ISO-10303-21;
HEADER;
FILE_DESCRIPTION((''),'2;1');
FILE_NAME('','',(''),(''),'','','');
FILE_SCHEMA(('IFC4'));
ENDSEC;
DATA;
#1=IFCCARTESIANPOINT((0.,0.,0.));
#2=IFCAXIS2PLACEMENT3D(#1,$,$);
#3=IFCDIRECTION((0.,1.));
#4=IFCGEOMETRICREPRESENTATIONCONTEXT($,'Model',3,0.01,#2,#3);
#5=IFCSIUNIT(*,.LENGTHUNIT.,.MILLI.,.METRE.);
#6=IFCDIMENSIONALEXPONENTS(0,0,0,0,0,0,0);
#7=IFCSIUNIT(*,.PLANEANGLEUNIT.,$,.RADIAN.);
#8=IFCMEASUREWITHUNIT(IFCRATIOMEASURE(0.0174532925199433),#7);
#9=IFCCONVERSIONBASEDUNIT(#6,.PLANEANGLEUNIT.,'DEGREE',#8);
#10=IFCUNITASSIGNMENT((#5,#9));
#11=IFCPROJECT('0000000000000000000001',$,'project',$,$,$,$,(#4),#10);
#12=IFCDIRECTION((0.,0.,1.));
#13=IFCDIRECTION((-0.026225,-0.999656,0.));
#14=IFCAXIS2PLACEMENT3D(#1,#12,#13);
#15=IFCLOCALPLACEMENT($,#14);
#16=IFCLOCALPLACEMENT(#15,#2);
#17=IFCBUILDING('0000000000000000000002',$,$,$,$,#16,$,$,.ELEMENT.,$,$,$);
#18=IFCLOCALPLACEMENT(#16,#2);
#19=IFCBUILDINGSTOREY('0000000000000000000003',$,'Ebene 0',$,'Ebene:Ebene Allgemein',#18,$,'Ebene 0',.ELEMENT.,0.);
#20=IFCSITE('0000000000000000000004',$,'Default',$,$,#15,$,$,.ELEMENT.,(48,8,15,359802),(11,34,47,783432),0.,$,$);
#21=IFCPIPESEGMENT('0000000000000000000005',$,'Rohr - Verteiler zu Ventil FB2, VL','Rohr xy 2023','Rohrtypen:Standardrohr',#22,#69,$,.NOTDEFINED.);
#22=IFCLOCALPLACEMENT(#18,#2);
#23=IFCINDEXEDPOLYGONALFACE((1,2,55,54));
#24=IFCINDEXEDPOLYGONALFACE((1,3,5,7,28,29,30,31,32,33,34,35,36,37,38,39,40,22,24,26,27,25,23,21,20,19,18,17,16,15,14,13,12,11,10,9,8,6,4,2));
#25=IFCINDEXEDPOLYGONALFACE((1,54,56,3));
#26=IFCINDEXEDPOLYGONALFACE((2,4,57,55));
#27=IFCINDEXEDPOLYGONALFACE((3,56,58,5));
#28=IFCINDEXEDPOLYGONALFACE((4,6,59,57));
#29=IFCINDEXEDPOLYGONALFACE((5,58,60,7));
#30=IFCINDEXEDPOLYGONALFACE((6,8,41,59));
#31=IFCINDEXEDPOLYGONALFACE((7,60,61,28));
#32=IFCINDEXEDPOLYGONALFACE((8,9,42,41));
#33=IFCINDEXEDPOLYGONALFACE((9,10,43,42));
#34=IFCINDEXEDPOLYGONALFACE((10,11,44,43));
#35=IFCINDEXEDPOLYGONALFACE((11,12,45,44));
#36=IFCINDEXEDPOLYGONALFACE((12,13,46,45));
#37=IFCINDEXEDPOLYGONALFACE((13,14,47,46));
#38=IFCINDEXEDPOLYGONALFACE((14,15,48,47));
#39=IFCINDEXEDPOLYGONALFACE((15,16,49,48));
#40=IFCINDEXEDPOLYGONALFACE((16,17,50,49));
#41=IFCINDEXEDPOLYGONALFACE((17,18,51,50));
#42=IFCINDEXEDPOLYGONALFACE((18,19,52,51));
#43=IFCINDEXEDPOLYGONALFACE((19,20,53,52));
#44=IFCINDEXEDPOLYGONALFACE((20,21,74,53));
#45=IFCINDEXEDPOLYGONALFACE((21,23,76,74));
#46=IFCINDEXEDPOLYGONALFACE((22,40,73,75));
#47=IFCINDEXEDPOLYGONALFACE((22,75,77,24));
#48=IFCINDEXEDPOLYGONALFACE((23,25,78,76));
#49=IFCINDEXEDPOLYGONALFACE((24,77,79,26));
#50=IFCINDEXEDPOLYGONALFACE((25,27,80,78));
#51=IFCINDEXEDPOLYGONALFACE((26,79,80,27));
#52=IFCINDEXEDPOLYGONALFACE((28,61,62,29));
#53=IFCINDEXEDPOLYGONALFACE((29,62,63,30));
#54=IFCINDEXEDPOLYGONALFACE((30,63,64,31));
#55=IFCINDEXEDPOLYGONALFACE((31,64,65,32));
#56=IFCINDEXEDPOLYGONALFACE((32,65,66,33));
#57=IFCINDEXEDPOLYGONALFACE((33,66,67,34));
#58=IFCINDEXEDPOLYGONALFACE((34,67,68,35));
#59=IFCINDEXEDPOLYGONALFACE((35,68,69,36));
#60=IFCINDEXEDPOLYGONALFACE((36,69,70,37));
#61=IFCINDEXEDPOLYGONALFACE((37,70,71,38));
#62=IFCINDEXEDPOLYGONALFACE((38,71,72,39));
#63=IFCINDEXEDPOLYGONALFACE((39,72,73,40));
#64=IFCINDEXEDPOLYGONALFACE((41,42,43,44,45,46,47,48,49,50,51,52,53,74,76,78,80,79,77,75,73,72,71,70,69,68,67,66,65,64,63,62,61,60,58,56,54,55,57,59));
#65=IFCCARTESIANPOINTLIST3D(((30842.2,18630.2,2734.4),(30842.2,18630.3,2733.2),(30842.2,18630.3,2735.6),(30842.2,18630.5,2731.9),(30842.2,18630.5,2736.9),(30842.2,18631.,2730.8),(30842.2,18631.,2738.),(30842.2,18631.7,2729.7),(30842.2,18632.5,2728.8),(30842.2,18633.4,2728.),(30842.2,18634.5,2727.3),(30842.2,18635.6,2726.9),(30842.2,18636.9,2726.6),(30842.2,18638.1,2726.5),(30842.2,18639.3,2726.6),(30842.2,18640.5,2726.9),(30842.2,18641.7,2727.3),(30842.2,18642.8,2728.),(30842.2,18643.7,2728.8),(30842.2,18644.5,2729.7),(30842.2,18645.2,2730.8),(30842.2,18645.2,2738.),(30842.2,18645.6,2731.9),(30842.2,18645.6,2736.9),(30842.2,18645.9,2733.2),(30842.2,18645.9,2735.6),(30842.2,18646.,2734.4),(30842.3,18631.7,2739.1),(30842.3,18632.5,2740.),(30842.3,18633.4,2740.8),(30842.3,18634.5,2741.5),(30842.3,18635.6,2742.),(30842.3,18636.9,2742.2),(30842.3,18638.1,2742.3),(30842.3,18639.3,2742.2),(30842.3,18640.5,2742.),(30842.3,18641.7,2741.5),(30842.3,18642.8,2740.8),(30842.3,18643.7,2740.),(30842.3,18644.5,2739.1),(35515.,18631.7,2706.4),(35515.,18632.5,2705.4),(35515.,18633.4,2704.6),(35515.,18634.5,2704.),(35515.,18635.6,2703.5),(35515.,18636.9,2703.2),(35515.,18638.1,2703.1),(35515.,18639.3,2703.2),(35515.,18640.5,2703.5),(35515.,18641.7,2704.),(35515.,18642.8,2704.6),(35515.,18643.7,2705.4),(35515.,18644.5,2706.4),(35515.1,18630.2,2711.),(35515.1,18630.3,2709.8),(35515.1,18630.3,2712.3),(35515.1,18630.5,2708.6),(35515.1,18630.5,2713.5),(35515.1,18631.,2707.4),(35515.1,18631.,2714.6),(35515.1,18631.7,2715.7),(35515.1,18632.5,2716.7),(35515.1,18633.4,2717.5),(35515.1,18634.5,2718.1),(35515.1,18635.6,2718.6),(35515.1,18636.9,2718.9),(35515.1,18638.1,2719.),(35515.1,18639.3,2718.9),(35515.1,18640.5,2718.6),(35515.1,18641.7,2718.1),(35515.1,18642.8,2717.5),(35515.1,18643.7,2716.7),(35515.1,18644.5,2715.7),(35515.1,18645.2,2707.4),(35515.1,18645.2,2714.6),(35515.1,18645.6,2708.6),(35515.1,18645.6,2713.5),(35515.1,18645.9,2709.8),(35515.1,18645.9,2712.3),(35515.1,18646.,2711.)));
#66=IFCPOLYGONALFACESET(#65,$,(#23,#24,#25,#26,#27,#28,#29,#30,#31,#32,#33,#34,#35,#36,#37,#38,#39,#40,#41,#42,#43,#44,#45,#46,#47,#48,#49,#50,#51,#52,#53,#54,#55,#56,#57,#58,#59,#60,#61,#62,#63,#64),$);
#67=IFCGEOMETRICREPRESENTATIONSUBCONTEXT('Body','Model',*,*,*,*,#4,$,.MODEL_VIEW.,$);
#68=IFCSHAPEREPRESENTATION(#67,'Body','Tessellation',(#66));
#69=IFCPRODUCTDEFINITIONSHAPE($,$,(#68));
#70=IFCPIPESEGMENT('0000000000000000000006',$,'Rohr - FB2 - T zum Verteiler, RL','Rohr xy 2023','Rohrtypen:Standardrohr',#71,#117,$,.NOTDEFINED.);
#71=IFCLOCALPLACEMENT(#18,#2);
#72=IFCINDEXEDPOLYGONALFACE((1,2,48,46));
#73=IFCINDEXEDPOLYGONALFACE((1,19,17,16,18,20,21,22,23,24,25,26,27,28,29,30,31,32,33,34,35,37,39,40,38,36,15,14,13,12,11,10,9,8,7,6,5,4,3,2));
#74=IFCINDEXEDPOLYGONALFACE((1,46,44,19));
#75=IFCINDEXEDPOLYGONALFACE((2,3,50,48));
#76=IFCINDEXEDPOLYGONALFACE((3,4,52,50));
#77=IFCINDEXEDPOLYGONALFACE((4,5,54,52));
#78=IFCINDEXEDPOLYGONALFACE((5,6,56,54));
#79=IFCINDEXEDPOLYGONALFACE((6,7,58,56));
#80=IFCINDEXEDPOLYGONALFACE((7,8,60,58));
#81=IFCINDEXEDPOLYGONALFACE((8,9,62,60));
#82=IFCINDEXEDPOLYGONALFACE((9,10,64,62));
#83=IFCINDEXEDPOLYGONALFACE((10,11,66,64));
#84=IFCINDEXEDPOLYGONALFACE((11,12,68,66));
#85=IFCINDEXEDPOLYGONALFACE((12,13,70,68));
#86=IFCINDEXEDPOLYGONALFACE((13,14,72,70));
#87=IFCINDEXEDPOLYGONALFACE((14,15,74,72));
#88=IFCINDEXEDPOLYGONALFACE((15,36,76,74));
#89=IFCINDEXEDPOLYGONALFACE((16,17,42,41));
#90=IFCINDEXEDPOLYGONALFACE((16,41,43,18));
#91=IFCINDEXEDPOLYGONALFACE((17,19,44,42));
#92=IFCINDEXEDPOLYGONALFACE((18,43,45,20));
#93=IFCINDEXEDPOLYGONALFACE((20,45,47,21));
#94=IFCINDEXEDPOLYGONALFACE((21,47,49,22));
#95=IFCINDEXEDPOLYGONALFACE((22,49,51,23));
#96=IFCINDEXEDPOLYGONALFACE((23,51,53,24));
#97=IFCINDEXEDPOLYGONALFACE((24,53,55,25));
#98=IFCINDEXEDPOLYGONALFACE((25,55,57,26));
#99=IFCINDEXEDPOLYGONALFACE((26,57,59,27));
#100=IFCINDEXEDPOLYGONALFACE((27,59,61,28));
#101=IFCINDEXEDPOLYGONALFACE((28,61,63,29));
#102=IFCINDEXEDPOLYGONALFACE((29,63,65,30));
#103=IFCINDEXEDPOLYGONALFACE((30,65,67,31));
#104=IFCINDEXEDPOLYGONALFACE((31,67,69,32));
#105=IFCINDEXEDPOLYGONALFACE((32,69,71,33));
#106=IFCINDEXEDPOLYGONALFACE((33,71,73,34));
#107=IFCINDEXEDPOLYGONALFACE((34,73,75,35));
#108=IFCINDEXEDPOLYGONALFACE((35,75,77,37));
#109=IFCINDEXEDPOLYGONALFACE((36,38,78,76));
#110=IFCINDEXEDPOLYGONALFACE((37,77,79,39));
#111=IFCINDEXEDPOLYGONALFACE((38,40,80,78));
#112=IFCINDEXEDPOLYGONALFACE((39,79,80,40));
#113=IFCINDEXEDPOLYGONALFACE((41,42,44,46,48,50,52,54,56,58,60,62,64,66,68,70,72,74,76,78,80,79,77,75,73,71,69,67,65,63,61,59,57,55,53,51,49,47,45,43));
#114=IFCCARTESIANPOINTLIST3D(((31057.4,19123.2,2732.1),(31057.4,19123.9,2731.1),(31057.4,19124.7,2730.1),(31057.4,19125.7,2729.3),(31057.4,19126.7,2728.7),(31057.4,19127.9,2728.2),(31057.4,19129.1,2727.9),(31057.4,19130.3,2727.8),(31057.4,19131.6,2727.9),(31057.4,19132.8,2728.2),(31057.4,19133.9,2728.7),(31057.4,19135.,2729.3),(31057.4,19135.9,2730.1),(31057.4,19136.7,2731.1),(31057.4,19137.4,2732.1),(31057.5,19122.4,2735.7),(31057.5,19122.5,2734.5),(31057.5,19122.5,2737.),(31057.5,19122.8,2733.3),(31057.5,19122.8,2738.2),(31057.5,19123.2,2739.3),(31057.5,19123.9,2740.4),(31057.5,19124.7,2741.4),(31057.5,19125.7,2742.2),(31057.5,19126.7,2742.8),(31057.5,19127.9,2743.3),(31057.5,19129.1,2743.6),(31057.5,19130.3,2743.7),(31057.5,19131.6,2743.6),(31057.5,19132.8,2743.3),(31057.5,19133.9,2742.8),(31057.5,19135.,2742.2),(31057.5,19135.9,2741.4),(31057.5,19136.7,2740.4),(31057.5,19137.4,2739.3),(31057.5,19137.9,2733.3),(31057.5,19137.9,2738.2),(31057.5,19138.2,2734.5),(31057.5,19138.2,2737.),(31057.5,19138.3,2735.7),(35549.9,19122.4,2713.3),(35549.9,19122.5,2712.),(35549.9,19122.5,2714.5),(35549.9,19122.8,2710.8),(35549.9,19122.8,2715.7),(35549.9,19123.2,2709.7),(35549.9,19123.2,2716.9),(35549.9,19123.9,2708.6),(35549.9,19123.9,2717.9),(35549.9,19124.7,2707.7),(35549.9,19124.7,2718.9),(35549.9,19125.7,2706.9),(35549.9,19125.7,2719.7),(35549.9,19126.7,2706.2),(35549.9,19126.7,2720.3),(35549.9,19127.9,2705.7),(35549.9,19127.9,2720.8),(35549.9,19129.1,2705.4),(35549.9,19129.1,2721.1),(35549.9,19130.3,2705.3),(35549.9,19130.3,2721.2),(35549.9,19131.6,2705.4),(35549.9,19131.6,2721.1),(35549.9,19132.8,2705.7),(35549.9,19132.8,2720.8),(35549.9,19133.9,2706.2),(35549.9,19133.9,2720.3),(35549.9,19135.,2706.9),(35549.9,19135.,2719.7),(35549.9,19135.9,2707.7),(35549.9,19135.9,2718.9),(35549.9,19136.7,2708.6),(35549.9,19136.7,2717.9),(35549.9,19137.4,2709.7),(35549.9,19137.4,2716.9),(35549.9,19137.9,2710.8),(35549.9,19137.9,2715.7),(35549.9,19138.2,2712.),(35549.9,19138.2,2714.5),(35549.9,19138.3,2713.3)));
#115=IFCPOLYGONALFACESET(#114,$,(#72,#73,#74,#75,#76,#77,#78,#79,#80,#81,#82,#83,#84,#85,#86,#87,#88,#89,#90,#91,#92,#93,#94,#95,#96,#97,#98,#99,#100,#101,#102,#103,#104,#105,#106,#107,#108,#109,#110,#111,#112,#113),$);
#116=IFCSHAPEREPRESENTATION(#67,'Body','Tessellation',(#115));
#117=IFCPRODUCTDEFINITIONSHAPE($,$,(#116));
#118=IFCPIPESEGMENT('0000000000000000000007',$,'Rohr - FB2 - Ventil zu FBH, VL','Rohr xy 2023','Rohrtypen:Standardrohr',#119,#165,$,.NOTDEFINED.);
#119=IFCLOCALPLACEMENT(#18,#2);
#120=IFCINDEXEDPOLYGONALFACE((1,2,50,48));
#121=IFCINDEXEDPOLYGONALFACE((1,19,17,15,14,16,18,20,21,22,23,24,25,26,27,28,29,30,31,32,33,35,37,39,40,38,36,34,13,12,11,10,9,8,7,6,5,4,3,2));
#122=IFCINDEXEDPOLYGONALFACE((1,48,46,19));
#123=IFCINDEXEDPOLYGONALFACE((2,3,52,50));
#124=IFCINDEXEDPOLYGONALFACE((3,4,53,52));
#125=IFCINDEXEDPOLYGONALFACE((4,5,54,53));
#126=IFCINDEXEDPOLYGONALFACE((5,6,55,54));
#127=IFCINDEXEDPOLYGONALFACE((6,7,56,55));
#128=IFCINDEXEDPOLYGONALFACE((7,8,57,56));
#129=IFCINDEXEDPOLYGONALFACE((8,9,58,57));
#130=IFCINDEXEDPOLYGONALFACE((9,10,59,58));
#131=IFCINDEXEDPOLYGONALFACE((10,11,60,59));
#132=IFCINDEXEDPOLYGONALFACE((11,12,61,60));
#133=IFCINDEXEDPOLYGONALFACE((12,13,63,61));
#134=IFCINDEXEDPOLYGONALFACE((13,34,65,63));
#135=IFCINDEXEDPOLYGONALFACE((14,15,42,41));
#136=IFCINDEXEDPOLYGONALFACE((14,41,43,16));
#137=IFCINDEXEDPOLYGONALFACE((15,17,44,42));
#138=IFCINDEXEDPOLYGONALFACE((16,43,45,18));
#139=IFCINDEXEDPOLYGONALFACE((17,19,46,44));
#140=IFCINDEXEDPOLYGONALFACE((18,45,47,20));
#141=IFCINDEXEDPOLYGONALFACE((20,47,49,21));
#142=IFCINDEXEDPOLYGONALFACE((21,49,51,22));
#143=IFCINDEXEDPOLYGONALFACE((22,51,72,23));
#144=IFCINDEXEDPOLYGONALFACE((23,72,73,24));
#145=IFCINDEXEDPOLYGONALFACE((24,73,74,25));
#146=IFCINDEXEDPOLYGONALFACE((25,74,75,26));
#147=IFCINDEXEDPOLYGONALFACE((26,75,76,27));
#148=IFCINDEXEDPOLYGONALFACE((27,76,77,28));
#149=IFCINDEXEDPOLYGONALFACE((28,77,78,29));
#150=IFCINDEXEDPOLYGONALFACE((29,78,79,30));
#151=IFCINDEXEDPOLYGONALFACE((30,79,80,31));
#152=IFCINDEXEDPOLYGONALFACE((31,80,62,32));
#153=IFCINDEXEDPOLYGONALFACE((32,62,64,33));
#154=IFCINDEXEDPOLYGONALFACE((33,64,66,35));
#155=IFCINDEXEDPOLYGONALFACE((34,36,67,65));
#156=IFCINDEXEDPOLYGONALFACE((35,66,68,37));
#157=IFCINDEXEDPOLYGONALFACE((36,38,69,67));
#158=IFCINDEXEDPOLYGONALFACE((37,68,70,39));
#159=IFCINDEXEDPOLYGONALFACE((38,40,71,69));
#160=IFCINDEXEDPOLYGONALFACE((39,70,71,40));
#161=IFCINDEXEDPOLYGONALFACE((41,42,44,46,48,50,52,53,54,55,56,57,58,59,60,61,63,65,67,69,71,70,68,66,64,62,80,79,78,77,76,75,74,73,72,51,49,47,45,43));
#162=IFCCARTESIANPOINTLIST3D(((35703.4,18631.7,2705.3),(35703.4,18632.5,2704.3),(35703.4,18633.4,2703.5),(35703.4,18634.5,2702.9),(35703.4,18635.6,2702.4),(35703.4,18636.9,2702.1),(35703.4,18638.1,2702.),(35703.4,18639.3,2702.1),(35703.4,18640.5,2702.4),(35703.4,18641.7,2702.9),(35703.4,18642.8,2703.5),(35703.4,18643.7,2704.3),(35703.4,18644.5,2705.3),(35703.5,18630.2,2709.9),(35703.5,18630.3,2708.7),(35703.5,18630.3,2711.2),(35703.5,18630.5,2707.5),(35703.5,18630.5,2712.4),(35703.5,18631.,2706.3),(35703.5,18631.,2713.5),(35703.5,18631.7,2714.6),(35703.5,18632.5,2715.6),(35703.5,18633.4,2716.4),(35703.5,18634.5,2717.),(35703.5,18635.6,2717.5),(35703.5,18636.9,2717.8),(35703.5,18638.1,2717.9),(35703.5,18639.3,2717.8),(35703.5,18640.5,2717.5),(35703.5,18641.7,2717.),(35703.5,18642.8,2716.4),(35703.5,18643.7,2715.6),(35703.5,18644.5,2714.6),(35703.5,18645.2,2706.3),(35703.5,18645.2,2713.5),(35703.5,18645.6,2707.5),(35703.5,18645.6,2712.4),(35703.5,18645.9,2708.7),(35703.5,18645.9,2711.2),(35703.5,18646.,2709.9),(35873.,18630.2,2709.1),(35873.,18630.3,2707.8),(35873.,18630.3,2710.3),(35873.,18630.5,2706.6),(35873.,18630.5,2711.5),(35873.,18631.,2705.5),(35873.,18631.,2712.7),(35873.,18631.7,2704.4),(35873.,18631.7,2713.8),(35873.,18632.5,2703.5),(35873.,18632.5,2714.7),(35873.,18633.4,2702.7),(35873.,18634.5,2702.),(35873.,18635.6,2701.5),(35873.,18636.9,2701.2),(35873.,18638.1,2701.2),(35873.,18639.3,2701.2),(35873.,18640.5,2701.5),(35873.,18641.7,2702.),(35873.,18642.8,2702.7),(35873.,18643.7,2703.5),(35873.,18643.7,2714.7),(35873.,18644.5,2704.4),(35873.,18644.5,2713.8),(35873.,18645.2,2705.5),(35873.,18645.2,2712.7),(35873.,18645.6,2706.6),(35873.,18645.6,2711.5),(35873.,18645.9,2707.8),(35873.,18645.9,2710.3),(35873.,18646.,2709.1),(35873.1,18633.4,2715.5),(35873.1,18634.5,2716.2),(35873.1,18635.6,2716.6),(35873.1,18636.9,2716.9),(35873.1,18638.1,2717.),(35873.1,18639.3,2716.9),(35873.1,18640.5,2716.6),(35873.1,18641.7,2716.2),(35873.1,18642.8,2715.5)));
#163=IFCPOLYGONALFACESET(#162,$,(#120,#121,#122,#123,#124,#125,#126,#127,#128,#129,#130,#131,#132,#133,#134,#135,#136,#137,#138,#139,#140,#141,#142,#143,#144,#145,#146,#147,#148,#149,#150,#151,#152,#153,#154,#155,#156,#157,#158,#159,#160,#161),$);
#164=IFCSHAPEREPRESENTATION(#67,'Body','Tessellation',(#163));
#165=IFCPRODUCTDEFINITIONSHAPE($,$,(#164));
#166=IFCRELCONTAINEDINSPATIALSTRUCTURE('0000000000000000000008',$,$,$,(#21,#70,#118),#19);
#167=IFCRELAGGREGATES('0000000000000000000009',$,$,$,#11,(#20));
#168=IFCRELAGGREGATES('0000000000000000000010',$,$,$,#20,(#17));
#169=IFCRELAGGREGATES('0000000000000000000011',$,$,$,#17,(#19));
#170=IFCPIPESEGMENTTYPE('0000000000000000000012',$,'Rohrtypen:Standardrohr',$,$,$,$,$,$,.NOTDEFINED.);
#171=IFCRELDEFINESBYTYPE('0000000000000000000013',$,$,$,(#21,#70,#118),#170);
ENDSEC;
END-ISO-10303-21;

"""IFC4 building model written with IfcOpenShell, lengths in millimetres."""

from ifc_helpers import new_model, entity, si_unit, converted_unit, direction, frame, origin, place, context, subcontext, project, spatial, indexed_curve, outline, extrude, type_object, element, save


model = new_model("IFC4")

# Units and contexts
model_context = context("Model", 3, precision=0.01, world=origin(), true_north=direction((0.0, 1.0)))
body_context = subcontext(model_context, "Body", "Model", "MODEL_VIEW")
ifc_project = project(units=[si_unit("LENGTHUNIT", "METRE", prefix="MILLI"), converted_unit("PLANEANGLEUNIT", "DEGREE", entity("IfcRatioMeasure", 0.0174532925199433), si_unit("PLANEANGLEUNIT", "RADIAN"), dimensions=[0, 0, 0, 0, 0, 0, 0])], contexts=[model_context])

# Site, building, storey
site_placement = place(None, frame((0.0, 0.0, 0.0), z_axis=(0.0, 0.0, 1.0), x_axis=(-0.026225, -0.999656, 0.0)))
site = spatial("IfcSite", under=ifc_project, at=site_placement, Name="Default", CompositionType="ELEMENT", RefLatitude=(48, 8, 15, 359802), RefLongitude=(11, 34, 47, 783432), RefElevation=0.0)
building_placement = place(site_placement, origin())
building = spatial("IfcBuilding", under=site, at=building_placement, CompositionType="ELEMENT")
storey_placement = place(building_placement, origin())
storey = spatial("IfcBuildingStorey", under=building, at=storey_placement, Name="Ebene 0", ObjectType="Ebene:Ebene Allgemein", LongName="Ebene 0", CompositionType="ELEMENT", Elevation=0.0)

# Pipe segments
pipe_segment_type = type_object("IfcPipeSegmentType", Name="Rohrtypen:Standardrohr", PredefinedType="NOTDEFINED")
pipe_segment_1_placement = place(storey_placement, origin())
element("IfcPipeSegment", 1, at=pipe_segment_1_placement, inside=storey, type_object=pipe_segment_type, Name="Rohr - Verteiler zu Ventil FB2, VL", Description="Rohr xy 2023", ObjectType="Rohrtypen:Standardrohr", PredefinedType="NOTDEFINED", context=body_context, shape_type="SweptSolid", body=[
    extrude(outline(indexed_curve([(7.9, 0.0), (7.8, 1.2), (7.6, 2.5), (7.1, 3.6), (6.4, 4.7), (5.6, 5.6), (4.7, 6.4), (3.6, 7.1), (2.5, 7.6), (1.2, 7.8), (0.0, 7.9), (-1.2, 7.8), (-2.5, 7.6), (-3.6, 7.1), (-4.7, 6.4), (-5.6, 5.6), (-6.4, 4.7), (-7.1, 3.6), (-7.6, 2.5), (-7.8, 1.2), (-7.9, 0.0), (-7.8, -1.2), (-7.6, -2.5), (-7.1, -3.6), (-6.4, -4.7), (-5.6, -5.6), (-4.7, -6.4), (-3.6, -7.1), (-2.5, -7.6), (-1.2, -7.8), (0.0, -7.9), (1.2, -7.8), (2.5, -7.6), (3.6, -7.1), (4.7, -6.4), (5.6, -5.6), (6.4, -4.7), (7.1, -3.6), (7.6, -2.5), (7.8, -1.2), (7.9, 0.0)], self_intersect=False)), frame((35515.1, 18638.1, 2711.0), z_axis=(-0.999988, 0.0, 0.005), x_axis=(0.0, 1.0, 0.0)), (0.0, 0.0, 1.0), 4672.9),
])
pipe_segment_2_placement = place(storey_placement, origin())
element("IfcPipeSegment", 2, at=pipe_segment_2_placement, inside=storey, type_object=pipe_segment_type, Name="Rohr - FB2 - T zum Verteiler, RL", Description="Rohr xy 2023", ObjectType="Rohrtypen:Standardrohr", PredefinedType="NOTDEFINED", context=body_context, shape_type="SweptSolid", body=[
    extrude(outline(indexed_curve([(7.9, 0.0), (7.8, 1.2), (7.6, 2.5), (7.1, 3.6), (6.4, 4.7), (5.6, 5.6), (4.7, 6.4), (3.6, 7.1), (2.5, 7.6), (1.2, 7.8), (0.0, 7.9), (-1.2, 7.8), (-2.5, 7.6), (-3.6, 7.1), (-4.7, 6.4), (-5.6, 5.6), (-6.4, 4.7), (-7.1, 3.6), (-7.6, 2.5), (-7.8, 1.2), (-7.9, 0.0), (-7.8, -1.2), (-7.6, -2.5), (-7.1, -3.6), (-6.4, -4.7), (-5.6, -5.6), (-4.7, -6.4), (-3.6, -7.1), (-2.5, -7.6), (-1.2, -7.8), (0.0, -7.9), (1.2, -7.8), (2.5, -7.6), (3.6, -7.1), (4.7, -6.4), (5.6, -5.6), (6.4, -4.7), (7.1, -3.6), (7.6, -2.5), (7.8, -1.2), (7.9, 0.0)], self_intersect=False)), frame((35549.9, 19130.3, 2713.3), z_axis=(-0.999988, 0.0, 0.005), x_axis=(0.0, 1.0, 0.0)), (0.0, 0.0, 1.0), 4492.5),
])
pipe_segment_3_placement = place(storey_placement, origin())
element("IfcPipeSegment", 3, at=pipe_segment_3_placement, inside=storey, type_object=pipe_segment_type, Name="Rohr - FB2 - Ventil zu FBH, VL", Description="Rohr xy 2023", ObjectType="Rohrtypen:Standardrohr", PredefinedType="NOTDEFINED", context=body_context, shape_type="SweptSolid", body=[
    extrude(outline(indexed_curve([(7.9, 0.0), (7.8, 1.2), (7.6, 2.5), (7.1, 3.6), (6.4, 4.7), (5.6, 5.6), (4.7, 6.4), (3.6, 7.1), (2.5, 7.6), (1.2, 7.8), (0.0, 7.9), (-1.2, 7.8), (-2.5, 7.6), (-3.6, 7.1), (-4.7, 6.4), (-5.6, 5.6), (-6.4, 4.7), (-7.1, 3.6), (-7.6, 2.5), (-7.8, 1.2), (-7.9, 0.0), (-7.8, -1.2), (-7.6, -2.5), (-7.1, -3.6), (-6.4, -4.7), (-5.6, -5.6), (-4.7, -6.4), (-3.6, -7.1), (-2.5, -7.6), (-1.2, -7.8), (0.0, -7.9), (1.2, -7.8), (2.5, -7.6), (3.6, -7.1), (4.7, -6.4), (5.6, -5.6), (6.4, -4.7), (7.1, -3.6), (7.6, -2.5), (7.8, -1.2), (7.9, 0.0)], self_intersect=False)), frame((35703.5, 18638.1, 2709.9), z_axis=(0.999988, 0.0, -0.005), x_axis=(0.0, 1.0, 0.0)), (0.0, 0.0, 1.0), 169.5),
])

save(model, "model.ifc")
